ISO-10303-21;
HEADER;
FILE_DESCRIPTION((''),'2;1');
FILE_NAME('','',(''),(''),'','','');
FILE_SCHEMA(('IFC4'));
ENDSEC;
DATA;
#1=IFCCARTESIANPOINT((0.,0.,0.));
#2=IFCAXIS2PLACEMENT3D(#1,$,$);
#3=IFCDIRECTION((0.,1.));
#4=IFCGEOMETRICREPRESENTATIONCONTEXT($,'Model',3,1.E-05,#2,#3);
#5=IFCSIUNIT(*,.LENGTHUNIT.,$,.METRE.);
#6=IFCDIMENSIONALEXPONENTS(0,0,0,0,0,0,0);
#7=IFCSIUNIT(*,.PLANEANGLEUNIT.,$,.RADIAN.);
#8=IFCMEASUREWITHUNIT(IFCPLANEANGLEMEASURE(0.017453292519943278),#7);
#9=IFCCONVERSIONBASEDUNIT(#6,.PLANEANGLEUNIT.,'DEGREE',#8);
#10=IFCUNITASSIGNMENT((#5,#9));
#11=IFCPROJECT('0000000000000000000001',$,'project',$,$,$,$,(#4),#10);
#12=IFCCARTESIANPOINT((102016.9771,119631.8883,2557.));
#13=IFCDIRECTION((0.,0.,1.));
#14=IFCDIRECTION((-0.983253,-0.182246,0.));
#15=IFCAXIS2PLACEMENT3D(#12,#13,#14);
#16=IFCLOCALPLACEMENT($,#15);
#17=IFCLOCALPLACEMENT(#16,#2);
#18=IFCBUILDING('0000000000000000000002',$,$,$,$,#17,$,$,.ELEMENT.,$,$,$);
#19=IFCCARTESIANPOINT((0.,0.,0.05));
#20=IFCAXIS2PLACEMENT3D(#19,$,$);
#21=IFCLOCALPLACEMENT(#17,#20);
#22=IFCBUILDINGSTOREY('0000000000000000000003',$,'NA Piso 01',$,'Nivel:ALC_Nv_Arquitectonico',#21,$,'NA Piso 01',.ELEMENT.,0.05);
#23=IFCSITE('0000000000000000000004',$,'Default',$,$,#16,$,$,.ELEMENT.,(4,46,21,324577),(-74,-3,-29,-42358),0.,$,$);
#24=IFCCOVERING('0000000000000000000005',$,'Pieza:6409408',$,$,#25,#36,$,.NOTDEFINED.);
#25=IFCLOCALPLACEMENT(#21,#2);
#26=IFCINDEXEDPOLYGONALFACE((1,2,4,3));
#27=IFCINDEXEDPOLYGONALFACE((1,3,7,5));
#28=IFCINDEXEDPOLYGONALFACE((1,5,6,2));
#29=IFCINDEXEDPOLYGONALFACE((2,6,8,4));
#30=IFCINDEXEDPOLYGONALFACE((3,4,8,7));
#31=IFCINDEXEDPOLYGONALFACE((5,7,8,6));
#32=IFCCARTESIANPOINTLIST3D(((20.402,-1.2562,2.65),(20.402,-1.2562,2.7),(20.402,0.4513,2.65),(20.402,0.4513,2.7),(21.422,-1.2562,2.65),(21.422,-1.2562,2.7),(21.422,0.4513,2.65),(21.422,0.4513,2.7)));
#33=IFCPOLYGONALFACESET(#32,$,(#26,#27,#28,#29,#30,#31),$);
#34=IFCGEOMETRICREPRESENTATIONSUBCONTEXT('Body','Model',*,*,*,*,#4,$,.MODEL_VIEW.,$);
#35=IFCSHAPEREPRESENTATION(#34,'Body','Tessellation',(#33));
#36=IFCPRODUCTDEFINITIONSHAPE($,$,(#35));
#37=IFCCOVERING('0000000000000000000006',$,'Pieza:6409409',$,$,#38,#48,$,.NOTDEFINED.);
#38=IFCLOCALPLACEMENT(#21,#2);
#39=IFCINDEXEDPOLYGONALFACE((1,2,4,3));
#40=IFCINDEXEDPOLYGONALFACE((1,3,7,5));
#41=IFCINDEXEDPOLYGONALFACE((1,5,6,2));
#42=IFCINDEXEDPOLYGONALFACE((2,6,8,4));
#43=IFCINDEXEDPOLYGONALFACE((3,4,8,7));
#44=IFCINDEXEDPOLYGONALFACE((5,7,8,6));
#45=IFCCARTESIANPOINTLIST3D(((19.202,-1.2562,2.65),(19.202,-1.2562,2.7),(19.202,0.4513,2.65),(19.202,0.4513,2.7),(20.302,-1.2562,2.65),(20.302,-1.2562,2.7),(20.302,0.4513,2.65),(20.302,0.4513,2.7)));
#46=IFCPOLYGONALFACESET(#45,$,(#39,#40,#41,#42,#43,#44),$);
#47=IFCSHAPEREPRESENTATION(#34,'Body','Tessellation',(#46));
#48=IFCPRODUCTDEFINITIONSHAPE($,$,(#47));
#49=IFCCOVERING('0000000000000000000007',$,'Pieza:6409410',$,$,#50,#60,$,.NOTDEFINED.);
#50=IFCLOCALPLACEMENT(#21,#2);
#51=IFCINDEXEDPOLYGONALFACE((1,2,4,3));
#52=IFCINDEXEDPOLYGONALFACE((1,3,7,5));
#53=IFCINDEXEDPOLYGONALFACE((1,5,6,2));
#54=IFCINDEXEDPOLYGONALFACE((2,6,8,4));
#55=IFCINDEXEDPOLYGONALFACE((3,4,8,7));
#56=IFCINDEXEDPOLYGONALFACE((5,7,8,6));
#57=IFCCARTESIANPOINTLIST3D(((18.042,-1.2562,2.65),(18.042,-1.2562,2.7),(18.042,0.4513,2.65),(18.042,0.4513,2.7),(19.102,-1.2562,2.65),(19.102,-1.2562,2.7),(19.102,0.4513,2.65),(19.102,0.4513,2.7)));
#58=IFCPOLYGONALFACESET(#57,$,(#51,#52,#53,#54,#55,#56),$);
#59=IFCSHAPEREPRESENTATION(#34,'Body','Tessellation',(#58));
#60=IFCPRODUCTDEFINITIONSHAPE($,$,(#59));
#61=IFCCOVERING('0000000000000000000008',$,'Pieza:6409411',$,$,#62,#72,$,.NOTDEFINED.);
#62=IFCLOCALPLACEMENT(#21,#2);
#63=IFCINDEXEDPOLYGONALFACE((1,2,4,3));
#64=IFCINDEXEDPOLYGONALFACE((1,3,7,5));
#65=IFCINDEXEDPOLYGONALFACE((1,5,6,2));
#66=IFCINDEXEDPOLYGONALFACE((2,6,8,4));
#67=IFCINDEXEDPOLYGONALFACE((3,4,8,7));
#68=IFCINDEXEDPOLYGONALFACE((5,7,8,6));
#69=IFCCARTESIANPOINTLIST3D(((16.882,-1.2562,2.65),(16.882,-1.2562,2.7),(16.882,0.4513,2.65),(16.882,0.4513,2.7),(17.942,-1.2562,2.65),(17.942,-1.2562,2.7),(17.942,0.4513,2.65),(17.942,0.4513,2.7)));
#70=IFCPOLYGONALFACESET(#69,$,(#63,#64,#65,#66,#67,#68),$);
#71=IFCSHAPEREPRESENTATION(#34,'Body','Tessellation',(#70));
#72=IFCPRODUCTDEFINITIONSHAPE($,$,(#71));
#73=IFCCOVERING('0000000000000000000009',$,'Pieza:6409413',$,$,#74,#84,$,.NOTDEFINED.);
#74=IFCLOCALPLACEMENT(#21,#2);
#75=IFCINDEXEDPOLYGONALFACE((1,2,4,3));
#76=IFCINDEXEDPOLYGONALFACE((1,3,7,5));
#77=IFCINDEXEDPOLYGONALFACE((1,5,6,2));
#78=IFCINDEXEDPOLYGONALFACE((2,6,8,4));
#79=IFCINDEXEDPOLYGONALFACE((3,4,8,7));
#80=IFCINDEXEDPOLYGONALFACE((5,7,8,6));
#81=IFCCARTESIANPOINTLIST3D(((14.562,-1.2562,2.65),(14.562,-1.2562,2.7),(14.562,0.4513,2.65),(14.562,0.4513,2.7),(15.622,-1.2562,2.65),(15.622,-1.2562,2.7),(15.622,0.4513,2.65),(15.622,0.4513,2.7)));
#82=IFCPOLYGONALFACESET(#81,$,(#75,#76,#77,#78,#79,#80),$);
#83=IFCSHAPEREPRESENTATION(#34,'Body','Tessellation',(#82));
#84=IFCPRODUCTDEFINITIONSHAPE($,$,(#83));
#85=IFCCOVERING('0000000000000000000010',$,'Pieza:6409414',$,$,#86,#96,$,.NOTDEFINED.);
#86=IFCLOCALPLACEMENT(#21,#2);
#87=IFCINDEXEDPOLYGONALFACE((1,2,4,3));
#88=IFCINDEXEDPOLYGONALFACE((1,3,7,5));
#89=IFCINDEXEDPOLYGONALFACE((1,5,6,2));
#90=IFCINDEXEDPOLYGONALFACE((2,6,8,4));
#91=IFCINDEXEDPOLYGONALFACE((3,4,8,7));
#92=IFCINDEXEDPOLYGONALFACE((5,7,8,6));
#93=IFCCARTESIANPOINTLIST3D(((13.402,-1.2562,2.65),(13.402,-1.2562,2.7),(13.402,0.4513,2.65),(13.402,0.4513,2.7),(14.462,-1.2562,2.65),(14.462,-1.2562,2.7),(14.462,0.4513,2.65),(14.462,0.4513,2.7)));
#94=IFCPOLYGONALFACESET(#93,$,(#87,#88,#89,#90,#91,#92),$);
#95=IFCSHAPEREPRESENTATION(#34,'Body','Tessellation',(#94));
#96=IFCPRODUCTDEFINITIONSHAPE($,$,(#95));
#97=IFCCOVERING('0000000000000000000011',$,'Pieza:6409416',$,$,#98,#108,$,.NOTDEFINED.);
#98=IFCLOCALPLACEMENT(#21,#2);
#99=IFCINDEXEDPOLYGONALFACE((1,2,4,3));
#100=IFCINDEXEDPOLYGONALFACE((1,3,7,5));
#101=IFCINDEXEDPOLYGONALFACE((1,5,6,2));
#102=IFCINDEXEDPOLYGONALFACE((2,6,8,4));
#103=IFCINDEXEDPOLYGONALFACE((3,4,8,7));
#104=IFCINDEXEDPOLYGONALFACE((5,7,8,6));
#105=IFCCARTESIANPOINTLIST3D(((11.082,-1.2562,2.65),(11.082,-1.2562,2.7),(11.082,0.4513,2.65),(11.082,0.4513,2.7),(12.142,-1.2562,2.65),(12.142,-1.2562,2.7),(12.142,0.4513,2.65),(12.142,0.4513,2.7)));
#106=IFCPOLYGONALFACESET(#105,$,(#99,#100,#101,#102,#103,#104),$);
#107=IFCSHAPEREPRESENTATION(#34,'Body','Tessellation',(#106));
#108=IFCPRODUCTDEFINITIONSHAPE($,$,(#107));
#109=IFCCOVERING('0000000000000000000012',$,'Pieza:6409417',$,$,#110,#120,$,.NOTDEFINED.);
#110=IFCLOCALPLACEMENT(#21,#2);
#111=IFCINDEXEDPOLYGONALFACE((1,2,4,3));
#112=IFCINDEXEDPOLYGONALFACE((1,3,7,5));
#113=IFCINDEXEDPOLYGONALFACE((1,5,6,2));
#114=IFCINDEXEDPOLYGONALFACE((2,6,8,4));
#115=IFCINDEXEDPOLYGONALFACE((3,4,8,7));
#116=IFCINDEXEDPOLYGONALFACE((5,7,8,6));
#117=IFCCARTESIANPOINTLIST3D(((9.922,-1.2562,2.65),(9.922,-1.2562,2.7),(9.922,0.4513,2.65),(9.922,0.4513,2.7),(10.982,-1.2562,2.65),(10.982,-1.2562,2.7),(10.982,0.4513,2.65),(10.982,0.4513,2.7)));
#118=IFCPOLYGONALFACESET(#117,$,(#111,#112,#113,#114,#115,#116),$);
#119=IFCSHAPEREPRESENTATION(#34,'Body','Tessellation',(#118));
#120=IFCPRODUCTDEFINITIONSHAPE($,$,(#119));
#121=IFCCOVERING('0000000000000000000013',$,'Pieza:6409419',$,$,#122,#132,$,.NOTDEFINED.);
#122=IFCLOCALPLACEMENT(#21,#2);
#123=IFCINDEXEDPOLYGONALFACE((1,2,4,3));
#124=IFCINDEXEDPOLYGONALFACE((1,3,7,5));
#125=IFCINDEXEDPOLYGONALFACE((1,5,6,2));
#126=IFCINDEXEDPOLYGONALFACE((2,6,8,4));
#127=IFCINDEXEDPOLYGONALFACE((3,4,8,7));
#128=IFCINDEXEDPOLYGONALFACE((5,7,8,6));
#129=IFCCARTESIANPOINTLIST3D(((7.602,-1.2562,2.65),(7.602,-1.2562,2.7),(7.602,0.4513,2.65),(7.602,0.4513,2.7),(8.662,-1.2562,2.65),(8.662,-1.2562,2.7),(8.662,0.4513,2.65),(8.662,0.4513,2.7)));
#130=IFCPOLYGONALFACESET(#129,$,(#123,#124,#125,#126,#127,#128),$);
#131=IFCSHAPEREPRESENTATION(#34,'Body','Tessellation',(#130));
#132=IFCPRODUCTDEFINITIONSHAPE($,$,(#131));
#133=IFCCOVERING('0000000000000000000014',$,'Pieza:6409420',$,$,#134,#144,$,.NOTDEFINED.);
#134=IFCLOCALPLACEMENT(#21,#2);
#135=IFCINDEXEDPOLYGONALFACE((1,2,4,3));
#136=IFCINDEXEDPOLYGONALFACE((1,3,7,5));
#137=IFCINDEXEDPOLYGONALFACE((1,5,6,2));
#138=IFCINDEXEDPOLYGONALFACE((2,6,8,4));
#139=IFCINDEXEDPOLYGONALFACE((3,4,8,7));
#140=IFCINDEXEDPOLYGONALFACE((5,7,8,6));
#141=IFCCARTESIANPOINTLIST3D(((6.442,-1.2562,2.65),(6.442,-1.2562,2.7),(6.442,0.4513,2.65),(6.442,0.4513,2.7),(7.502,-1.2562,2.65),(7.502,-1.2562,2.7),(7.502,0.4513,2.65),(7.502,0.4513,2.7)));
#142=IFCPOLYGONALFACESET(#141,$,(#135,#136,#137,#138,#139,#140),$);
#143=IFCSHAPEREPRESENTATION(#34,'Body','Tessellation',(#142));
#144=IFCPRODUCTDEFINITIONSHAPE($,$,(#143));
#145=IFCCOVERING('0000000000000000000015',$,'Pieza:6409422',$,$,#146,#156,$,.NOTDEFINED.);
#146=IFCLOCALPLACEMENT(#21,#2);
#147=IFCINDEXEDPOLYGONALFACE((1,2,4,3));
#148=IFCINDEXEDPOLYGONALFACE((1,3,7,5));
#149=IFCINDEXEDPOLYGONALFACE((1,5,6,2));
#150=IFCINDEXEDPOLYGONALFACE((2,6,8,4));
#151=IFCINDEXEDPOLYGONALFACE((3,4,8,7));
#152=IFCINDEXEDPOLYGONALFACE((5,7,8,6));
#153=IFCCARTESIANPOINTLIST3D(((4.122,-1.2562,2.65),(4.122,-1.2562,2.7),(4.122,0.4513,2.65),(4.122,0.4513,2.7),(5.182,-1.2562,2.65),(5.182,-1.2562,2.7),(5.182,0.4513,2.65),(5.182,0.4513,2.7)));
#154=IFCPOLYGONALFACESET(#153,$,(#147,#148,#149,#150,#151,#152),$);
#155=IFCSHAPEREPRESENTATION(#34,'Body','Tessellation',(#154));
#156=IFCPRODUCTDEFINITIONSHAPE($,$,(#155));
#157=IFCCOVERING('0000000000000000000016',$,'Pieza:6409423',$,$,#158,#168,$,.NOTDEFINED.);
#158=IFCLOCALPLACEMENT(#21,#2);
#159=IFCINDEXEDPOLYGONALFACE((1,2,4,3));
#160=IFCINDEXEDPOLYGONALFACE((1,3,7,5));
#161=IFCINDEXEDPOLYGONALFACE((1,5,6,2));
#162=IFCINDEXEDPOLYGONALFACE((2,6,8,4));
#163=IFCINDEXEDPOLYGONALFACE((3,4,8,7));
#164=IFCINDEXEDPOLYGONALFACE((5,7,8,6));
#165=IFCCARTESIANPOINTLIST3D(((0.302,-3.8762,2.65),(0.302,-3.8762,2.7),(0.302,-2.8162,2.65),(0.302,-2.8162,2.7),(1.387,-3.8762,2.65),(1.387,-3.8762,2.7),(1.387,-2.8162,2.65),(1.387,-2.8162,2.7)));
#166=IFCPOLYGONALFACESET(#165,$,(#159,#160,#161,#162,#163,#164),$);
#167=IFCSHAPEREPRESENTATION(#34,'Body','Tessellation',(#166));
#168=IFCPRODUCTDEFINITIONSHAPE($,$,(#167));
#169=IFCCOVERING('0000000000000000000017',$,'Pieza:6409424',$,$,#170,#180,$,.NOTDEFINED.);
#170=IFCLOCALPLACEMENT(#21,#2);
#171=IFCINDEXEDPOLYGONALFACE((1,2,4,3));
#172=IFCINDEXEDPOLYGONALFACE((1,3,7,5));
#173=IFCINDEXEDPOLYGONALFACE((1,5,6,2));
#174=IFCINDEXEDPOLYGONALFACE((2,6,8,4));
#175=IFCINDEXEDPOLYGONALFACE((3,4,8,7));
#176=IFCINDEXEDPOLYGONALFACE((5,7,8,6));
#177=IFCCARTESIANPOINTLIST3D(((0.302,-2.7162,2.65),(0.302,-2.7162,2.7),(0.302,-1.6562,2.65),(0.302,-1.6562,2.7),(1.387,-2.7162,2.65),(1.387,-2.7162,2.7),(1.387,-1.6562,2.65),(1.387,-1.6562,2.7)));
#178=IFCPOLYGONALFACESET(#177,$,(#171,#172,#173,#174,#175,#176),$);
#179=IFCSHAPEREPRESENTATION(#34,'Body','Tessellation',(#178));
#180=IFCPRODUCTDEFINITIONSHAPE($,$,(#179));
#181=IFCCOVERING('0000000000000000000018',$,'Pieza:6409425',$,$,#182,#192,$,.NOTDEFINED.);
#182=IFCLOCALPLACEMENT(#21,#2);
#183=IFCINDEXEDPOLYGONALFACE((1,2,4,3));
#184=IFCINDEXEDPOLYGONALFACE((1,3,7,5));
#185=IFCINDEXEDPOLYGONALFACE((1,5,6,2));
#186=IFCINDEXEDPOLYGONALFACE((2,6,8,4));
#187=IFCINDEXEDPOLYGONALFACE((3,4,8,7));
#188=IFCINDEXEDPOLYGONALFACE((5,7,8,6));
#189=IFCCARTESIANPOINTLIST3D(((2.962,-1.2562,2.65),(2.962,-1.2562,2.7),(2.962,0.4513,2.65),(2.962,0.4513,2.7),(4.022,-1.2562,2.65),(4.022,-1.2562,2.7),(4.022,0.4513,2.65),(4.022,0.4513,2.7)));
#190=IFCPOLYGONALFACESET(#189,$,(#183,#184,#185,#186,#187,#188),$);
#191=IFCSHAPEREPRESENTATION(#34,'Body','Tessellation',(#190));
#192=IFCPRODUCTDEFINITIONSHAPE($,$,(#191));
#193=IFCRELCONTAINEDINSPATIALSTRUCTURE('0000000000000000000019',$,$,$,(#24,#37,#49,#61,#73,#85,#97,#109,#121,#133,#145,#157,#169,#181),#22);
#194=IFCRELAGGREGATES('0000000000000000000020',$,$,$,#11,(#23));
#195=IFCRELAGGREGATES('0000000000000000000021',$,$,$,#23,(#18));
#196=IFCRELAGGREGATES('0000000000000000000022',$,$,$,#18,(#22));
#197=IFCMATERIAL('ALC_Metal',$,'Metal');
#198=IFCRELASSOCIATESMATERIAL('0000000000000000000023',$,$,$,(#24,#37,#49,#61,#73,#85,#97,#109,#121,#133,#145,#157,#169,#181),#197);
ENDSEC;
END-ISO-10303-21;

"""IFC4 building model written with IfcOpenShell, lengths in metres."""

from ifc_helpers import new_model, entity, si_unit, converted_unit, direction, frame, frame_2d, origin, place, context, subcontext, project, spatial, rectangle, extrude, material, element, save


model = new_model("IFC4")

# Units and contexts
model_context = context("Model", 3, precision=1e-05, world=origin(), true_north=direction((0.0, 1.0)))
body_context = subcontext(model_context, "Body", "Model", "MODEL_VIEW")
ifc_project = project(units=[si_unit("LENGTHUNIT", "METRE"), converted_unit("PLANEANGLEUNIT", "DEGREE", entity("IfcPlaneAngleMeasure", 0.017453292519943278), si_unit("PLANEANGLEUNIT", "RADIAN"), dimensions=[0, 0, 0, 0, 0, 0, 0])], contexts=[model_context])

# Site, building, storey
site_placement = place(None, frame((102016.9771, 119631.8883, 2557.0), z_axis=(0.0, 0.0, 1.0), x_axis=(-0.983253, -0.182246, 0.0)))
site = spatial("IfcSite", under=ifc_project, at=site_placement, Name="Default", CompositionType="ELEMENT", RefLatitude=(4, 46, 21, 324577), RefLongitude=(-74, -3, -29, -42358), RefElevation=0.0)
building_placement = place(site_placement, origin())
building = spatial("IfcBuilding", under=site, at=building_placement, CompositionType="ELEMENT")
storey_placement = place(building_placement, frame((0.0, 0.0, 0.05)))
storey = spatial("IfcBuildingStorey", under=building, at=storey_placement, Name="NA Piso 01", ObjectType="Nivel:ALC_Nv_Arquitectonico", LongName="NA Piso 01", CompositionType="ELEMENT", Elevation=0.05)

# Coverings
ifc_material_1 = material(Name="ALC_Metal", Category="Metal")
covering_1_placement = place(storey_placement, frame((0.0, 0.0, 2.65)))
element("IfcCovering", 1, at=covering_1_placement, inside=storey, material=ifc_material_1, Name="Pieza:6409408", PredefinedType="NOTDEFINED", context=body_context, shape_type="SweptSolid", body=[
    extrude(rectangle(XDim=1.7075, YDim=1.02, at=frame_2d((0.0, 0.0), x_axis=(1.0, 0.0))), frame((20.912, -0.4024, 0.0), z_axis=(0.0, 0.0, 1.0), x_axis=(0.0, -1.0, 0.0)), (0.0, 0.0, 1.0), 0.05),
])
covering_2_placement = place(storey_placement, frame((0.0, 0.0, 2.65)))
element("IfcCovering", 2, at=covering_2_placement, inside=storey, material=ifc_material_1, Name="Pieza:6409409", PredefinedType="NOTDEFINED", context=body_context, shape_type="SweptSolid", body=[
    extrude(rectangle(XDim=1.7075, YDim=1.1, at=frame_2d((0.0, 0.0), x_axis=(1.0, 0.0))), frame((19.752, -0.4024, 0.0), z_axis=(0.0, 0.0, 1.0), x_axis=(0.0, -1.0, 0.0)), (0.0, 0.0, 1.0), 0.05),
])
covering_3_placement = place(storey_placement, frame((0.0, 0.0, 2.65)))
element("IfcCovering", 3, at=covering_3_placement, inside=storey, material=ifc_material_1, Name="Pieza:6409410", PredefinedType="NOTDEFINED", context=body_context, shape_type="SweptSolid", body=[
    extrude(rectangle(XDim=1.7075, YDim=1.06, at=frame_2d((0.0, 0.0), x_axis=(1.0, 0.0))), frame((18.572, -0.4024, 0.0), z_axis=(0.0, 0.0, 1.0), x_axis=(0.0, -1.0, 0.0)), (0.0, 0.0, 1.0), 0.05),
])
covering_4_placement = place(storey_placement, frame((0.0, 0.0, 2.65)))
element("IfcCovering", 4, at=covering_4_placement, inside=storey, material=ifc_material_1, Name="Pieza:6409411", PredefinedType="NOTDEFINED", context=body_context, shape_type="SweptSolid", body=[
    extrude(rectangle(XDim=1.7075, YDim=1.06, at=frame_2d((0.0, 0.0), x_axis=(1.0, 0.0))), frame((17.412, -0.4024, 0.0), z_axis=(0.0, 0.0, 1.0), x_axis=(0.0, -1.0, 0.0)), (0.0, 0.0, 1.0), 0.05),
])
covering_5_placement = place(storey_placement, frame((0.0, 0.0, 2.65)))
element("IfcCovering", 5, at=covering_5_placement, inside=storey, material=ifc_material_1, Name="Pieza:6409413", PredefinedType="NOTDEFINED", context=body_context, shape_type="SweptSolid", body=[
    extrude(rectangle(XDim=1.7075, YDim=1.06, at=frame_2d((0.0, 0.0), x_axis=(1.0, 0.0))), frame((15.092, -0.4024, 0.0), z_axis=(0.0, 0.0, 1.0), x_axis=(0.0, -1.0, 0.0)), (0.0, 0.0, 1.0), 0.05),
])
covering_6_placement = place(storey_placement, frame((0.0, 0.0, 2.65)))
element("IfcCovering", 6, at=covering_6_placement, inside=storey, material=ifc_material_1, Name="Pieza:6409414", PredefinedType="NOTDEFINED", context=body_context, shape_type="SweptSolid", body=[
    extrude(rectangle(XDim=1.7075, YDim=1.06, at=frame_2d((0.0, 0.0), x_axis=(1.0, 0.0))), frame((13.932, -0.4024, 0.0), z_axis=(0.0, 0.0, 1.0), x_axis=(0.0, -1.0, 0.0)), (0.0, 0.0, 1.0), 0.05),
])
covering_7_placement = place(storey_placement, frame((0.0, 0.0, 2.65)))
element("IfcCovering", 7, at=covering_7_placement, inside=storey, material=ifc_material_1, Name="Pieza:6409416", PredefinedType="NOTDEFINED", context=body_context, shape_type="SweptSolid", body=[
    extrude(rectangle(XDim=1.7075, YDim=1.06, at=frame_2d((0.0, 0.0), x_axis=(1.0, 0.0))), frame((11.612, -0.4024, 0.0), z_axis=(0.0, 0.0, 1.0), x_axis=(0.0, -1.0, 0.0)), (0.0, 0.0, 1.0), 0.05),
])
covering_8_placement = place(storey_placement, frame((0.0, 0.0, 2.65)))
element("IfcCovering", 8, at=covering_8_placement, inside=storey, material=ifc_material_1, Name="Pieza:6409417", PredefinedType="NOTDEFINED", context=body_context, shape_type="SweptSolid", body=[
    extrude(rectangle(XDim=1.7075, YDim=1.06, at=frame_2d((0.0, 0.0), x_axis=(1.0, 0.0))), frame((10.452, -0.4024, 0.0), z_axis=(0.0, 0.0, 1.0), x_axis=(0.0, -1.0, 0.0)), (0.0, 0.0, 1.0), 0.05),
])
covering_9_placement = place(storey_placement, frame((0.0, 0.0, 2.65)))
element("IfcCovering", 9, at=covering_9_placement, inside=storey, material=ifc_material_1, Name="Pieza:6409419", PredefinedType="NOTDEFINED", context=body_context, shape_type="SweptSolid", body=[
    extrude(rectangle(XDim=1.7075, YDim=1.06, at=frame_2d((0.0, 0.0), x_axis=(1.0, 0.0))), frame((8.132, -0.4024, 0.0), z_axis=(0.0, 0.0, 1.0), x_axis=(0.0, -1.0, 0.0)), (0.0, 0.0, 1.0), 0.05),
])
covering_10_placement = place(storey_placement, frame((0.0, 0.0, 2.65)))
element("IfcCovering", 10, at=covering_10_placement, inside=storey, material=ifc_material_1, Name="Pieza:6409420", PredefinedType="NOTDEFINED", context=body_context, shape_type="SweptSolid", body=[
    extrude(rectangle(XDim=1.7075, YDim=1.06, at=frame_2d((0.0, 0.0), x_axis=(1.0, 0.0))), frame((6.972, -0.4024, 0.0), z_axis=(0.0, 0.0, 1.0), x_axis=(0.0, -1.0, 0.0)), (0.0, 0.0, 1.0), 0.05),
])
covering_11_placement = place(storey_placement, frame((0.0, 0.0, 2.65)))
element("IfcCovering", 11, at=covering_11_placement, inside=storey, material=ifc_material_1, Name="Pieza:6409422", PredefinedType="NOTDEFINED", context=body_context, shape_type="SweptSolid", body=[
    extrude(rectangle(XDim=1.7075, YDim=1.06, at=frame_2d((0.0, 0.0), x_axis=(1.0, 0.0))), frame((4.652, -0.4024, 0.0), z_axis=(0.0, 0.0, 1.0), x_axis=(0.0, -1.0, 0.0)), (0.0, 0.0, 1.0), 0.05),
])
covering_12_placement = place(storey_placement, frame((0.0, 0.0, 2.65)))
element("IfcCovering", 12, at=covering_12_placement, inside=storey, material=ifc_material_1, Name="Pieza:6409423", PredefinedType="NOTDEFINED", context=body_context, shape_type="SweptSolid", body=[
    extrude(rectangle(XDim=1.06, YDim=1.085, at=frame_2d((0.0, 0.0), x_axis=(1.0, 0.0))), frame((0.8445, -3.3462, 0.0), z_axis=(0.0, 0.0, 1.0), x_axis=(0.0, -1.0, 0.0)), (0.0, 0.0, 1.0), 0.05),
])
covering_13_placement = place(storey_placement, frame((0.0, 0.0, 2.65)))
element("IfcCovering", 13, at=covering_13_placement, inside=storey, material=ifc_material_1, Name="Pieza:6409424", PredefinedType="NOTDEFINED", context=body_context, shape_type="SweptSolid", body=[
    extrude(rectangle(XDim=1.06, YDim=1.085, at=frame_2d((0.0, 0.0), x_axis=(1.0, 0.0))), frame((0.8445, -2.1862, 0.0), z_axis=(0.0, 0.0, 1.0), x_axis=(0.0, -1.0, 0.0)), (0.0, 0.0, 1.0), 0.05),
])
covering_14_placement = place(storey_placement, frame((0.0, 0.0, 2.65)))
element("IfcCovering", 14, at=covering_14_placement, inside=storey, material=ifc_material_1, Name="Pieza:6409425", PredefinedType="NOTDEFINED", context=body_context, shape_type="SweptSolid", body=[
    extrude(rectangle(XDim=1.7075, YDim=1.06, at=frame_2d((0.0, 0.0), x_axis=(1.0, 0.0))), frame((3.492, -0.4024, 0.0), z_axis=(0.0, 0.0, 1.0), x_axis=(0.0, -1.0, 0.0)), (0.0, 0.0, 1.0), 0.05),
])

save(model, "model.ifc")
